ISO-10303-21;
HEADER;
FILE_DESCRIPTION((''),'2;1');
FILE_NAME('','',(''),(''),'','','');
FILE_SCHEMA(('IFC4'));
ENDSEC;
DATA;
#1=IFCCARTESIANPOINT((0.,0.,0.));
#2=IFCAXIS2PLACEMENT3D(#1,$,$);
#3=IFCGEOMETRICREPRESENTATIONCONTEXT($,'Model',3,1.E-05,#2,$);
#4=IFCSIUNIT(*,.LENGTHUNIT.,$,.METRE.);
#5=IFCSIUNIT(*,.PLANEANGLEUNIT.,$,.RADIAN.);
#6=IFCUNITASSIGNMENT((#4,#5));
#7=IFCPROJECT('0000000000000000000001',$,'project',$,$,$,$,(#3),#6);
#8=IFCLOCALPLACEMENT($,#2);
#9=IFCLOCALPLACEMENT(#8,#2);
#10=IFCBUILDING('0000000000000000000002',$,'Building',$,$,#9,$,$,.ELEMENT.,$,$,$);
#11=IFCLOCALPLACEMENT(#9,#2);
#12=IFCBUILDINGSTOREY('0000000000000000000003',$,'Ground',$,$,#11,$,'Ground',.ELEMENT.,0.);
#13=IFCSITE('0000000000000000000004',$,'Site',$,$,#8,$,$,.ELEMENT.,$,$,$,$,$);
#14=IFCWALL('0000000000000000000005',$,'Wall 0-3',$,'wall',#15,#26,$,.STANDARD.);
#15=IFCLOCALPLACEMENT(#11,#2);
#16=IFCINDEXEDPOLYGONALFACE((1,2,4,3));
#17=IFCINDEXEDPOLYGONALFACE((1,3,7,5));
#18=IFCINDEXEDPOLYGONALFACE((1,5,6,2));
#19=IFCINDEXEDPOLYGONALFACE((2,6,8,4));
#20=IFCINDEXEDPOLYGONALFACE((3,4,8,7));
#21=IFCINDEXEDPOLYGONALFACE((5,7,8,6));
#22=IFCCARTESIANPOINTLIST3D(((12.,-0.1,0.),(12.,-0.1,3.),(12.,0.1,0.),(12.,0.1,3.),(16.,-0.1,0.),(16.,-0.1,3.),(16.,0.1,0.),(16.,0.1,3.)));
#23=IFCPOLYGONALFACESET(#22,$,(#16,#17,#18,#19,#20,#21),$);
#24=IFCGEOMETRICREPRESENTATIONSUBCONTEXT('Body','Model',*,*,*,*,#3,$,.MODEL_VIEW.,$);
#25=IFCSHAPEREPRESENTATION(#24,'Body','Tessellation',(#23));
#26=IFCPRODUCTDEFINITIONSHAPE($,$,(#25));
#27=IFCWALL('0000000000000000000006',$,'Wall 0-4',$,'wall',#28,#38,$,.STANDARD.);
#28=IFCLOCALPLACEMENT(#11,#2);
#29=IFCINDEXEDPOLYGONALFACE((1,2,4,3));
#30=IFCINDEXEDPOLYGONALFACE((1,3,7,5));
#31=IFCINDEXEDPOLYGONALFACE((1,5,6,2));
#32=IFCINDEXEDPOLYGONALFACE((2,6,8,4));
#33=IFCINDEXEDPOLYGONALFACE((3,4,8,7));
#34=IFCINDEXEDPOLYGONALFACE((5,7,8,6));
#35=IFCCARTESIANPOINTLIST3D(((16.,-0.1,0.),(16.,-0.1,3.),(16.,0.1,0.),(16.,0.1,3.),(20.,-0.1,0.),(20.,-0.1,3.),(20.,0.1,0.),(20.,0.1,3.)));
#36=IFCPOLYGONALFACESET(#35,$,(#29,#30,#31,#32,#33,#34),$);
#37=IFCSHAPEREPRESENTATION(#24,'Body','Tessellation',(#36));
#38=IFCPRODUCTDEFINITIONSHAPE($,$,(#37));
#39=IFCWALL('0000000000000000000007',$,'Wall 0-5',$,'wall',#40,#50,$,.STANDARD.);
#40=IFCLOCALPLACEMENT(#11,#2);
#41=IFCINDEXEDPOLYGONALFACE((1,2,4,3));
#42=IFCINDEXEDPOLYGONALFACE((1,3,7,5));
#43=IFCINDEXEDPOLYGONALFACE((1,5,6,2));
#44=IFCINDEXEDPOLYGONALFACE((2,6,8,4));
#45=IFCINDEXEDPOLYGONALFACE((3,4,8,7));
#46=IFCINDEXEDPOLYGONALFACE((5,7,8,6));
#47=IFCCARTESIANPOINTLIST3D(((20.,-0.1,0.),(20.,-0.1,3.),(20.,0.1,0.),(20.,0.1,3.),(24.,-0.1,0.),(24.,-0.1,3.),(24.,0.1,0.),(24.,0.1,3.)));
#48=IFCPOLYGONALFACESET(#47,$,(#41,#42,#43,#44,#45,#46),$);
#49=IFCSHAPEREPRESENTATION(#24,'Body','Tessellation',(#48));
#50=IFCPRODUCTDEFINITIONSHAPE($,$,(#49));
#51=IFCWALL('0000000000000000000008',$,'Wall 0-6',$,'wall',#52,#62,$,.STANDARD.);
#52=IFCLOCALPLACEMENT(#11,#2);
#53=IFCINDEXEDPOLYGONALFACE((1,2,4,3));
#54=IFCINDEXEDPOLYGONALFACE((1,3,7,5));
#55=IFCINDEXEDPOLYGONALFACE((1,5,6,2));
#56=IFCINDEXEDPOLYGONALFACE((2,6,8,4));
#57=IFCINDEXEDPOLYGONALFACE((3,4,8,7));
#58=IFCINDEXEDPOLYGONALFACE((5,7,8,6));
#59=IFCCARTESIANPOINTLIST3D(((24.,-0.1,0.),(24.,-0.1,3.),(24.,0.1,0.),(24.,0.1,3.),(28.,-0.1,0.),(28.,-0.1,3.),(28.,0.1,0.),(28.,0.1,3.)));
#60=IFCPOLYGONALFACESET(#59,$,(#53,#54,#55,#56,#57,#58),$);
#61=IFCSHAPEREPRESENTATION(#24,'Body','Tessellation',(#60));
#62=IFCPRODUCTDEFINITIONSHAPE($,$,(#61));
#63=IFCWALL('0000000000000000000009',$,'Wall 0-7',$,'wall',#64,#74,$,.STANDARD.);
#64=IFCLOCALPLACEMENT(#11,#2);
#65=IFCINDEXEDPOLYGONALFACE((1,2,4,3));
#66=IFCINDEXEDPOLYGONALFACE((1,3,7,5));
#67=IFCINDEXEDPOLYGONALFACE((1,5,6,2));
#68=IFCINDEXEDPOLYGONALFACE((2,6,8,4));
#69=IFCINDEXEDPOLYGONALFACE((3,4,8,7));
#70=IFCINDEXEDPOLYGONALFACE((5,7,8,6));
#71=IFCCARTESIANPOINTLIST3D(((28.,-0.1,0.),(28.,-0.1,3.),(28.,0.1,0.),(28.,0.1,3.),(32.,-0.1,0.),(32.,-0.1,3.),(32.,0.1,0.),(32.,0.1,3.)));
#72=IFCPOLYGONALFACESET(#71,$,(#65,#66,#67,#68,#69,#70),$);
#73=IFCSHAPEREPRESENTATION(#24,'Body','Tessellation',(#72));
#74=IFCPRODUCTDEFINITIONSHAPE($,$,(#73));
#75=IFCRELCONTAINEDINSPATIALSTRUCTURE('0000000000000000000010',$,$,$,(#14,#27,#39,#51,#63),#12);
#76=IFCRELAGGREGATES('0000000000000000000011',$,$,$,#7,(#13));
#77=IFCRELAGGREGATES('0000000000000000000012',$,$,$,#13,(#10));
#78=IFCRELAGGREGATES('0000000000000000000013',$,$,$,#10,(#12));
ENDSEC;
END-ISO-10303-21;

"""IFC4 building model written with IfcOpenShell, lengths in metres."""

from ifc_helpers import new_model, si_unit, frame, frame_2d, origin, place, context, subcontext, project, spatial, rectangle, extrude, element, save


model = new_model("IFC4")

# Units and contexts
model_context = context("Model", 3, precision=1e-05, world=origin())
body_context = subcontext(model_context, "Body", "Model", "MODEL_VIEW")
ifc_project = project(units=[si_unit("LENGTHUNIT", "METRE"), si_unit("PLANEANGLEUNIT", "RADIAN")], contexts=[model_context])

# Site, building, storey
site_placement = place(None, origin())
site = spatial("IfcSite", under=ifc_project, at=site_placement, Name="Site", CompositionType="ELEMENT")
building_placement = place(site_placement, origin())
building = spatial("IfcBuilding", under=site, at=building_placement, Name="Building", CompositionType="ELEMENT")
storey_placement = place(building_placement, origin())
storey = spatial("IfcBuildingStorey", under=building, at=storey_placement, Name="Ground", LongName="Ground", CompositionType="ELEMENT", Elevation=0.0)

# Walls
for number, where, z_axis, x_axis, name in (
    (1, (12.0, 0.0, 0.0), (0.0, 0.0, 1.0), (1.0, 0.0, 0.0), "Wall 0-3"),
    (2, (16.0, 0.0, 0.0), (0.0, 0.0, 1.0), (1.0, 0.0, 0.0), "Wall 0-4"),
    (3, (20.0, 0.0, 0.0), (0.0, 0.0, 1.0), (1.0, 0.0, 0.0), "Wall 0-5"),
    (4, (24.0, 0.0, 0.0), (0.0, 0.0, 1.0), (1.0, 0.0, 0.0), "Wall 0-6"),
    (5, (28.0, 0.0, 0.0), (0.0, 0.0, 1.0), (1.0, 0.0, 0.0), "Wall 0-7"),
):
    element("IfcWall", number, at=place(storey_placement, frame(where, z_axis=z_axis, x_axis=x_axis)), inside=storey, Name=name, ObjectType="wall", PredefinedType="STANDARD", context=body_context, shape_type="SweptSolid", body=[
        extrude(rectangle(XDim=4.0, YDim=0.2, at=frame_2d((2.0, 0.0))), origin(), (0.0, 0.0, 1.0), 3.0),
    ])

save(model, "model.ifc")
